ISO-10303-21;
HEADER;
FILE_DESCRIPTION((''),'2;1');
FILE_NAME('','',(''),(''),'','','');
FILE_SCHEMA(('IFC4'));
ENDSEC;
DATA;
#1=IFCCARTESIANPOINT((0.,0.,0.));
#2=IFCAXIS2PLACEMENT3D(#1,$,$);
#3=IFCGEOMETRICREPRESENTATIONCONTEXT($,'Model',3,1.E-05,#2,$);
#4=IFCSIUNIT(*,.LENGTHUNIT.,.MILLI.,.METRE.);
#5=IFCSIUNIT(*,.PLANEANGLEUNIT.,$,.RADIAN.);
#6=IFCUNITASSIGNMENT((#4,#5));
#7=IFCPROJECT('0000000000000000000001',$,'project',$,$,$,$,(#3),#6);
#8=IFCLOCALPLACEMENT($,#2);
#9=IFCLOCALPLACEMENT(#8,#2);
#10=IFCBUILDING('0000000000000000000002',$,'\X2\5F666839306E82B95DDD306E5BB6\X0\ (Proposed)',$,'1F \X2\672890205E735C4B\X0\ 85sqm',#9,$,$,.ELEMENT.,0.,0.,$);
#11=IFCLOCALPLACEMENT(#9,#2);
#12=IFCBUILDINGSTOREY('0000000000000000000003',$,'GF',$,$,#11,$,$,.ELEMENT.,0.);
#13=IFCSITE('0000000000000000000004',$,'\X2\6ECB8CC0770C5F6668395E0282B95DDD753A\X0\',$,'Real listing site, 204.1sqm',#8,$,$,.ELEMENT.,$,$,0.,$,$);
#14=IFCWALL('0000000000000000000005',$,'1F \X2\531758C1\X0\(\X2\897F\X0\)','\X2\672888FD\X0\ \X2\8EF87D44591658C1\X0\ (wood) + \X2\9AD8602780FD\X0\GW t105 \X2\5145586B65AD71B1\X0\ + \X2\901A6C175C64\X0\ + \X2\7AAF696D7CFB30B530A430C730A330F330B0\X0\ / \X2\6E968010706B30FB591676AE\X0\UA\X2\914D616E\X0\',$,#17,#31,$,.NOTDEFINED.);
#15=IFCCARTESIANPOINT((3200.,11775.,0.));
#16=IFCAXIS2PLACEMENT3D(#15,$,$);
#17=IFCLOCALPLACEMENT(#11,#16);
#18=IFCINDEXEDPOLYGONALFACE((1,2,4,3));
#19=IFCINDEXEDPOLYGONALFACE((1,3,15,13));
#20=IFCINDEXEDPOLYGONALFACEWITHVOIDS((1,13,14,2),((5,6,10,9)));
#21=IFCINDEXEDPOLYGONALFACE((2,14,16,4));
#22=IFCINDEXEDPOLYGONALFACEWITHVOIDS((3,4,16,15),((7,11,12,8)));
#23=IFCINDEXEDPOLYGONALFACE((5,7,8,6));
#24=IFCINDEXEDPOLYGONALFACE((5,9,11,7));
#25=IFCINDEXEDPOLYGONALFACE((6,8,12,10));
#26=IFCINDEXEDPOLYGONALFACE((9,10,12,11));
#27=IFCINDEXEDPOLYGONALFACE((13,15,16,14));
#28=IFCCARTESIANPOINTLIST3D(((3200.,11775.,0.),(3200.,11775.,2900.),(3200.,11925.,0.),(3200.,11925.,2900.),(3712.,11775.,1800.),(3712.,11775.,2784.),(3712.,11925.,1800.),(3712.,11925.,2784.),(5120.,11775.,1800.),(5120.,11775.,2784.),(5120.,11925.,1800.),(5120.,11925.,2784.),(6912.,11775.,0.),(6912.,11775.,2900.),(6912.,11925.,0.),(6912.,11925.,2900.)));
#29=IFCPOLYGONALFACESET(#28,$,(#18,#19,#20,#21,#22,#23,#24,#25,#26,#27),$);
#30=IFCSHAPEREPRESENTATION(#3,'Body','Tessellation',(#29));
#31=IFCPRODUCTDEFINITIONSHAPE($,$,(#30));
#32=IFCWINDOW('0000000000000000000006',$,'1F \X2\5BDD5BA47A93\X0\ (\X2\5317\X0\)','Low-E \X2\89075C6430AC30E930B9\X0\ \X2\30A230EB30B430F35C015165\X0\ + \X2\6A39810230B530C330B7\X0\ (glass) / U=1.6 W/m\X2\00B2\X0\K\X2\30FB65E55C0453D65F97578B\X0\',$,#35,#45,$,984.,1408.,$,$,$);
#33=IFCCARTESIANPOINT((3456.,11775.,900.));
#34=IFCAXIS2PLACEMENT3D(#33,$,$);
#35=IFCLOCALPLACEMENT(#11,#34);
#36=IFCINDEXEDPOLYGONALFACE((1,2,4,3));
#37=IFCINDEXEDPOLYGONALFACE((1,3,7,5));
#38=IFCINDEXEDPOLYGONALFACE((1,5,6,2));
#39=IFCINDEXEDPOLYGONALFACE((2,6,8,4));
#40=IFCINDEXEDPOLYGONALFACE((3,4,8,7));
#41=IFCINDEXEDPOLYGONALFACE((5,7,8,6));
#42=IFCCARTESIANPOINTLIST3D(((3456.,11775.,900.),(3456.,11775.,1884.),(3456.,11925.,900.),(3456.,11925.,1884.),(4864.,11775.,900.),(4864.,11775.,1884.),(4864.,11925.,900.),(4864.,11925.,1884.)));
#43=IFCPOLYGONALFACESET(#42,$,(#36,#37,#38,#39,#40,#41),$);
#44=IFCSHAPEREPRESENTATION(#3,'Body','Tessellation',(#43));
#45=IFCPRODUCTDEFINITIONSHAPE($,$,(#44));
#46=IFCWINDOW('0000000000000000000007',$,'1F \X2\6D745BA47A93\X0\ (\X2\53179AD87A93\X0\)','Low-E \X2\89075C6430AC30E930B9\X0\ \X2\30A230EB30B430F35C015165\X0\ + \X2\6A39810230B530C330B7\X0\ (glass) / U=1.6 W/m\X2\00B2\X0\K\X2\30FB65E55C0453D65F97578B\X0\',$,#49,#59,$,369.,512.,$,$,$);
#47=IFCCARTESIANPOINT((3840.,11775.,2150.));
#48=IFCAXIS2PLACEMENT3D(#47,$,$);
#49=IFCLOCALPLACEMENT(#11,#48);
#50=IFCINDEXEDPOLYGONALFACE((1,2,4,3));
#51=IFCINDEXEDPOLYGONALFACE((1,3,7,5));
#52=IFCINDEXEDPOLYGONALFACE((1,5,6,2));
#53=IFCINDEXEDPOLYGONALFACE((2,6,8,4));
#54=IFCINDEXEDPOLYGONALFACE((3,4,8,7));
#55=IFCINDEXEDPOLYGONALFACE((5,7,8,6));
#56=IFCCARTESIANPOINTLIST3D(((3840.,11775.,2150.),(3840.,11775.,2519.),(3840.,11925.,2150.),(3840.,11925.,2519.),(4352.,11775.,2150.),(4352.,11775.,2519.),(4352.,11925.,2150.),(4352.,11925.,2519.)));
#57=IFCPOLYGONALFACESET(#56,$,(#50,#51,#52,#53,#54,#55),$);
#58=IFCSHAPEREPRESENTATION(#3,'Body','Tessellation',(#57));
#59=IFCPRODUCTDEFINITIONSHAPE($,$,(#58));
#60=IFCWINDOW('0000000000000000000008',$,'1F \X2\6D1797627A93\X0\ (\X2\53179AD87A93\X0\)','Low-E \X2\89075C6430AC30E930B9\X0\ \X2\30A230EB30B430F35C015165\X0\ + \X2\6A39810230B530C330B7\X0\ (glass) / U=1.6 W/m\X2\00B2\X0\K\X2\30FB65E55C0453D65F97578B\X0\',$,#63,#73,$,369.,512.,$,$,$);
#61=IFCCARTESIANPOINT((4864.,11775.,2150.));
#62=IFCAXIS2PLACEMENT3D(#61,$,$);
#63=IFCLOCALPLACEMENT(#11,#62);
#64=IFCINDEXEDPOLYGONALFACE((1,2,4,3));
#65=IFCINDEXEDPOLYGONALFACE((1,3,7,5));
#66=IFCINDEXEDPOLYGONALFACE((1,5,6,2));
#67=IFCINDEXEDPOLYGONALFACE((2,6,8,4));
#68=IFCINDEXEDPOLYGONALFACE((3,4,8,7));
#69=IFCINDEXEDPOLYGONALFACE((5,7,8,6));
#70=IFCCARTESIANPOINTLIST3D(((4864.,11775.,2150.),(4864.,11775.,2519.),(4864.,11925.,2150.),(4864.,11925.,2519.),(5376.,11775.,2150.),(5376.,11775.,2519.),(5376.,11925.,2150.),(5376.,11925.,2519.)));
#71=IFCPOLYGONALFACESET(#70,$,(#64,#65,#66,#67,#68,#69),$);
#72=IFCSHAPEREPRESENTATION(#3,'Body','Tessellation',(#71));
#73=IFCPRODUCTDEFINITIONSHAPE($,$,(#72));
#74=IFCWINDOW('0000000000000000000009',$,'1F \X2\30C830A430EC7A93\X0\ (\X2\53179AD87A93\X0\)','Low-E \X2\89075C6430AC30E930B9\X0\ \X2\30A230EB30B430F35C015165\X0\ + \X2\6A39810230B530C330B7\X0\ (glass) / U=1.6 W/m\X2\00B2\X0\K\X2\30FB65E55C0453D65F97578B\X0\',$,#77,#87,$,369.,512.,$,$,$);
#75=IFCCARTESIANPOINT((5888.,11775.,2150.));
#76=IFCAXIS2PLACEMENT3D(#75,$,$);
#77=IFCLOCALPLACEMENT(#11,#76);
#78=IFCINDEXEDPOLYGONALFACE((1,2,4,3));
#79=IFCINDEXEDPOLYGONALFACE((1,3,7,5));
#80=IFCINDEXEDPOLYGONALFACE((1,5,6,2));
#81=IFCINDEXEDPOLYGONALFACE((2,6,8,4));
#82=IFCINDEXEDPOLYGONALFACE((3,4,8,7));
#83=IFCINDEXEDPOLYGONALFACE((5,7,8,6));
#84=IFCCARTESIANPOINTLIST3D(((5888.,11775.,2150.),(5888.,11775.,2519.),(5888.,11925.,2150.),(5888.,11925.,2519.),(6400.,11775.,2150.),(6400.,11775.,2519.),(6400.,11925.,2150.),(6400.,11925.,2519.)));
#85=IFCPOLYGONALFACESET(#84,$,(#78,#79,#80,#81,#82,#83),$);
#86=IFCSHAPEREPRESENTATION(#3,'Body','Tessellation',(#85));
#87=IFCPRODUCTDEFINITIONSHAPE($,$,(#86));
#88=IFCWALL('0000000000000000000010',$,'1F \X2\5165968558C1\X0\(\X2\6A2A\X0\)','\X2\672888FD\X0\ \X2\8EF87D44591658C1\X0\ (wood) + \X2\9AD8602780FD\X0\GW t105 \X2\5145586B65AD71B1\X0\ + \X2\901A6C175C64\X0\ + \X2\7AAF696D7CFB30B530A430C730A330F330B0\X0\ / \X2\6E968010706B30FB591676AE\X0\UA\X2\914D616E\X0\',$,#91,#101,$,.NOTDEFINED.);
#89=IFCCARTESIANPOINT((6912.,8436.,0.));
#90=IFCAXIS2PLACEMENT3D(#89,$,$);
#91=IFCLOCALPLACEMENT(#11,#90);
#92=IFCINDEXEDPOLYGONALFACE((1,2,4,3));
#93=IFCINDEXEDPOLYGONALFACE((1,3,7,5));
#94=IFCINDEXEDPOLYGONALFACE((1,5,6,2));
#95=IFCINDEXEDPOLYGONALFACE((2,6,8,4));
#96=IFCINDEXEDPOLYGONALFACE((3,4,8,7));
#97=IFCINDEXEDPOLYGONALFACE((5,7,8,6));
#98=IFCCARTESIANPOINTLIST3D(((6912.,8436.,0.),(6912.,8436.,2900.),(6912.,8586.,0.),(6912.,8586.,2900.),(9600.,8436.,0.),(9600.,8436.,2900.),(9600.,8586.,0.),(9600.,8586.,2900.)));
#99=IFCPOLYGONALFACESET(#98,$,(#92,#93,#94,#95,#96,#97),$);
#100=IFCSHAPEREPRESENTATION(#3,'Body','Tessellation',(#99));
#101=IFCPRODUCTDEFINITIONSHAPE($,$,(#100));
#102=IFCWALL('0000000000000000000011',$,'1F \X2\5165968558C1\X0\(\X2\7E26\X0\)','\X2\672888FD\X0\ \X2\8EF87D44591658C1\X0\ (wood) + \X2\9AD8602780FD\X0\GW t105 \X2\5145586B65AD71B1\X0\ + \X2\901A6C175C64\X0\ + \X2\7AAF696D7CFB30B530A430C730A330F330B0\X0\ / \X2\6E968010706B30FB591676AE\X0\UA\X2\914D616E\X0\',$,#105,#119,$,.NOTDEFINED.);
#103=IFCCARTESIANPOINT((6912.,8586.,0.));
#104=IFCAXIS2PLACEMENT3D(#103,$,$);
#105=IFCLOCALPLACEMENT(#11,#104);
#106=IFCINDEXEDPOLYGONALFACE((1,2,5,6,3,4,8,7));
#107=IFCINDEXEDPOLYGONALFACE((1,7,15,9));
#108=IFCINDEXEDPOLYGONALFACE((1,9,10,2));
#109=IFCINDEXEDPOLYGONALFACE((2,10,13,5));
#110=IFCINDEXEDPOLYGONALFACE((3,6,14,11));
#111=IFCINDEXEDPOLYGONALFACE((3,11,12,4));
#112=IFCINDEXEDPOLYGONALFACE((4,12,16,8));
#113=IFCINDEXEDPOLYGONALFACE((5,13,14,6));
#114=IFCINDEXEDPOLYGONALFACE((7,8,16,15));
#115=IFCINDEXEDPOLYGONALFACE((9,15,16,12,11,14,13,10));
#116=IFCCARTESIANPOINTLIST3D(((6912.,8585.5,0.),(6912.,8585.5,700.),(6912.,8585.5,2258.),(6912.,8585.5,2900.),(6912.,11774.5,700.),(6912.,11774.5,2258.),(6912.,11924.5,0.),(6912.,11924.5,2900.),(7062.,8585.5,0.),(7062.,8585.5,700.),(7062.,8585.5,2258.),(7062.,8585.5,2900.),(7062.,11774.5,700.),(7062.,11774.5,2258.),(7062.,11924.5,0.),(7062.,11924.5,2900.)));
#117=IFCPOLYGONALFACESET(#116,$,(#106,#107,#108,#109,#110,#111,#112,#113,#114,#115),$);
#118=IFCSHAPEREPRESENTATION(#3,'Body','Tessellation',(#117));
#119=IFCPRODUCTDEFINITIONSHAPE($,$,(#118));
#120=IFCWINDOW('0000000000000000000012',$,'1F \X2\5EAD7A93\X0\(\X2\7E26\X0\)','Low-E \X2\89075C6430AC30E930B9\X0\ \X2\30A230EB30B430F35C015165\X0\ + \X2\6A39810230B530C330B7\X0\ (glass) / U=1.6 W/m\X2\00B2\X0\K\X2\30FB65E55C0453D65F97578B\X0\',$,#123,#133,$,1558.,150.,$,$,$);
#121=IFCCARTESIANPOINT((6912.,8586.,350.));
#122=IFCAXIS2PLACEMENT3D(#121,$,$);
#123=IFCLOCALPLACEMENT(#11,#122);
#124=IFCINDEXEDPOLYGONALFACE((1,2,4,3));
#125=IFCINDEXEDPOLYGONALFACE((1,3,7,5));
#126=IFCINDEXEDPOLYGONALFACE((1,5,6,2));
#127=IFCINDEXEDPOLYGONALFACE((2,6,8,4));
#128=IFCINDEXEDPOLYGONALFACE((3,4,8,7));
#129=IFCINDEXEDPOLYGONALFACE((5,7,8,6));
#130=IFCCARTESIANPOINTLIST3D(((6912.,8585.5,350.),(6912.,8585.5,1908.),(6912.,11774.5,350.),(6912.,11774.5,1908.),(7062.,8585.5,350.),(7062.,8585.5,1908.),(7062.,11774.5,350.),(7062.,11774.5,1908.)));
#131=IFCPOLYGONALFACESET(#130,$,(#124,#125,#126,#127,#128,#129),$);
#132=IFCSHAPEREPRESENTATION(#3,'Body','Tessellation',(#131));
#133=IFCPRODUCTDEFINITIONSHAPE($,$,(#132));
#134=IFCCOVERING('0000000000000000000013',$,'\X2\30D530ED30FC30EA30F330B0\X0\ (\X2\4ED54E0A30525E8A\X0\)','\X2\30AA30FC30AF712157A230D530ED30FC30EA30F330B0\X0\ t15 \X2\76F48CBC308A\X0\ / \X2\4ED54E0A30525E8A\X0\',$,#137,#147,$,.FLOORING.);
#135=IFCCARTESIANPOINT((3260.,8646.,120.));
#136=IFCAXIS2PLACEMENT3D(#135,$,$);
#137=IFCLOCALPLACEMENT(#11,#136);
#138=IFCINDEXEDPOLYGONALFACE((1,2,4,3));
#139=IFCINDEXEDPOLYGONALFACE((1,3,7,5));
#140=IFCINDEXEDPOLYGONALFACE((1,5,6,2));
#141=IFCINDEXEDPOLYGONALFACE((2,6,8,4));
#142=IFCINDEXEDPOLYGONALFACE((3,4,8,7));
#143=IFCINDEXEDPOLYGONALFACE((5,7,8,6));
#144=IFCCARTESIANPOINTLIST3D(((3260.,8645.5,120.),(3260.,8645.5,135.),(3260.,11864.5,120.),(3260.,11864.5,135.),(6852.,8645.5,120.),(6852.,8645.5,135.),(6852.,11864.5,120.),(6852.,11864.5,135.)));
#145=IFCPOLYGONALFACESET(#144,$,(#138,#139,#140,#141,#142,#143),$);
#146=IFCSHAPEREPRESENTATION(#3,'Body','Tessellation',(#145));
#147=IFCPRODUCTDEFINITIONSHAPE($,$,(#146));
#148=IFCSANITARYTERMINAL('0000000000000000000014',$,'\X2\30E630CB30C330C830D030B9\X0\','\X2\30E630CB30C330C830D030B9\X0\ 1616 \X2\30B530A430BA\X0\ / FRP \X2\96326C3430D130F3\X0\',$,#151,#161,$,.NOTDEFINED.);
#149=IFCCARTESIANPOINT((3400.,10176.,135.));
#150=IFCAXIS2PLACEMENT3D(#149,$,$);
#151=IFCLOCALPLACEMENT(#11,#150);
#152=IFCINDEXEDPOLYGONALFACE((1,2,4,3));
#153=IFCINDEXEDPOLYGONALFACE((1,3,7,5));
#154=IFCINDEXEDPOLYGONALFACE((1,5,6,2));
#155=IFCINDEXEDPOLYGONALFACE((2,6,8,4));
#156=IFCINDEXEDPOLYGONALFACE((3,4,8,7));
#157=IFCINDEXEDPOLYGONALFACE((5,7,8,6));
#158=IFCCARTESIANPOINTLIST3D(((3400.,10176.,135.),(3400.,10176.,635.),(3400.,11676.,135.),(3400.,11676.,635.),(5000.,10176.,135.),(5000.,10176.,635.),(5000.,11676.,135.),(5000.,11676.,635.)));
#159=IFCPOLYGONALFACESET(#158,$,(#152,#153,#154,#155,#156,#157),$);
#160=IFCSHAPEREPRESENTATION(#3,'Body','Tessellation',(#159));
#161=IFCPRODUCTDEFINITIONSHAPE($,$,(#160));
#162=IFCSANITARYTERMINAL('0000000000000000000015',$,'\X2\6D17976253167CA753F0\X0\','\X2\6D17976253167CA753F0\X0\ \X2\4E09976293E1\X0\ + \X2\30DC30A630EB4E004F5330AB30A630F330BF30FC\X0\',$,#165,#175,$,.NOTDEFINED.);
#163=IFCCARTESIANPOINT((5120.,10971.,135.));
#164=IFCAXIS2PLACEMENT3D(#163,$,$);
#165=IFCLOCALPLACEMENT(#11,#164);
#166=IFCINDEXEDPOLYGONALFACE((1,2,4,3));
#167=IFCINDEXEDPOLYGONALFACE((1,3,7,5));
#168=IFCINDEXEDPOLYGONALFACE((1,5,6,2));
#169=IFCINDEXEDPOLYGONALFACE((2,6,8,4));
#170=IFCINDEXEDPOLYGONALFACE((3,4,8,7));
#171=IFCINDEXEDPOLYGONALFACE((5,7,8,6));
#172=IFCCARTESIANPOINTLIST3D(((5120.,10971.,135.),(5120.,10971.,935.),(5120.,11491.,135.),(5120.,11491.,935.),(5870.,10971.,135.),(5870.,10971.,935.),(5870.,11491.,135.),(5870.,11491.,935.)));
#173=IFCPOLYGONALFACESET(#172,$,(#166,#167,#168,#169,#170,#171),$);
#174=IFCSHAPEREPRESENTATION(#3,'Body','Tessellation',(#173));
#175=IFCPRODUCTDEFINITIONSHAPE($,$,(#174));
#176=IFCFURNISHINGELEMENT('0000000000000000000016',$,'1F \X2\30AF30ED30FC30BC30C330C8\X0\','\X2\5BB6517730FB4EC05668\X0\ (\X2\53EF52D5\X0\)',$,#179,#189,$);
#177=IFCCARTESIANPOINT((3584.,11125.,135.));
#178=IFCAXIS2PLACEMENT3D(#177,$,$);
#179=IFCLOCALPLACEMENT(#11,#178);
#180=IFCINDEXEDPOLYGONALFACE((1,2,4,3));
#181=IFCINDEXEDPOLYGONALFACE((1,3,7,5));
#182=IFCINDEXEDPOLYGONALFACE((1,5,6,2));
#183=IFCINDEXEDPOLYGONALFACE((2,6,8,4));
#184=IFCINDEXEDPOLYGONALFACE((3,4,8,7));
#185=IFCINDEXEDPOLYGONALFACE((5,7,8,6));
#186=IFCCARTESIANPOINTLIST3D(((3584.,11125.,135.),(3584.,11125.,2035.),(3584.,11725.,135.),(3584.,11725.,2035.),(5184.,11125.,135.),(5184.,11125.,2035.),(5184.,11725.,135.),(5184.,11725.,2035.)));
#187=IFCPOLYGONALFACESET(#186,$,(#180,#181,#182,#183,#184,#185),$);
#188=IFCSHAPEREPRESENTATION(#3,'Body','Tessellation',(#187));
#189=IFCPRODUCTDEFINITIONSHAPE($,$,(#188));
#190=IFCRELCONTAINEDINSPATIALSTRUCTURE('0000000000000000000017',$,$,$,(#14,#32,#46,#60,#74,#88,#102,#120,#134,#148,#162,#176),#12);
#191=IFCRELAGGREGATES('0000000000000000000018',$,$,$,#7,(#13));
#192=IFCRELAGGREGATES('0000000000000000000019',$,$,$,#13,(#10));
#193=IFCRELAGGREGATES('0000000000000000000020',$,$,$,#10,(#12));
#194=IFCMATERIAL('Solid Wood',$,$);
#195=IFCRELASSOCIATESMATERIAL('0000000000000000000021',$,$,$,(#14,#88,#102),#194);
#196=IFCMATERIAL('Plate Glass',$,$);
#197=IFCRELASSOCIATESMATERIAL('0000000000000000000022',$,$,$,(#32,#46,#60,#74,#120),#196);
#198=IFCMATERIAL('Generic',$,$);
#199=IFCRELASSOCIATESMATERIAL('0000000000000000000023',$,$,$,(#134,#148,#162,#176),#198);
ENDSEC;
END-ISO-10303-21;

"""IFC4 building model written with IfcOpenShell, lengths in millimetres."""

from ifc_helpers import new_model, si_unit, frame, frame_2d, origin, place, context, project, spatial, rectangle, extrude, material, element, fill, save


model = new_model("IFC4")

# Units and contexts
model_context = context("Model", 3, precision=1e-05, world=origin())
ifc_project = project(units=[si_unit("LENGTHUNIT", "METRE", prefix="MILLI"), si_unit("PLANEANGLEUNIT", "RADIAN")], contexts=[model_context])

# Site, building, storey
site_placement = place(None, origin())
site = spatial("IfcSite", under=ifc_project, at=site_placement, Name="滋賀県彦根市芹川町", ObjectType="Real listing site, 204.1sqm", CompositionType="ELEMENT", RefElevation=0.0)
building_placement = place(site_placement, origin())
building = spatial("IfcBuilding", under=site, at=building_placement, Name="彦根の芹川の家 (Proposed)", ObjectType="1F 木造平屋 85sqm", CompositionType="ELEMENT", ElevationOfRefHeight=0.0, ElevationOfTerrain=0.0)
storey_placement = place(building_placement, origin())
storey = spatial("IfcBuildingStorey", under=building, at=storey_placement, Name="GF", CompositionType="ELEMENT", Elevation=0.0)

# Shared definitions
ifc_material_1 = material(Name="Solid Wood")

# Wall, openings, windows
wall_1_placement = place(storey_placement, frame((3200.0, 11775.0, 0.0)))
wall_1 = element("IfcWall", 1, at=wall_1_placement, inside=storey, material=ifc_material_1, Name="1F 北壁(西)", Description="木製 軸組外壁 (wood) + 高性能GW t105 充填断熱 + 通気層 + 窯業系サイディング / 準耐火・外皮UA配慮", PredefinedType="NOTDEFINED", context=model_context, shape_type="SweptSolid", body=[
    extrude(rectangle(XDim=3712.0, YDim=150.0, at=frame_2d((1856.0, 75.0))), frame((3200.0, 11775.0, 0.0)), (0.0, 0.0, 1.0), 2900.0),
])
opening_1_placement = place(storey_placement, frame((3456.0, 11775.0, 900.0)))
opening_1 = element("IfcOpeningElement", 2, at=opening_1_placement, cuts=wall_1, PredefinedType="NOTDEFINED", context=model_context, shape_type="SweptSolid", body=[
    extrude(rectangle(XDim=1408.0, YDim=150.0, at=frame_2d((704.0, 75.0))), frame((3456.0, 11775.0, 900.0)), (0.0, 0.0, 1.0), 984.0),
])
opening_2_placement = place(storey_placement, frame((3840.0, 11775.0, 2150.0)))
opening_2 = element("IfcOpeningElement", 3, at=opening_2_placement, cuts=wall_1, PredefinedType="NOTDEFINED", context=model_context, shape_type="SweptSolid", body=[
    extrude(rectangle(XDim=512.0, YDim=150.0, at=frame_2d((256.0, 75.0))), frame((3840.0, 11775.0, 2150.0)), (0.0, 0.0, 1.0), 369.0),
])
opening_3_placement = place(storey_placement, frame((4864.0, 11775.0, 2150.0)))
opening_3 = element("IfcOpeningElement", 4, at=opening_3_placement, cuts=wall_1, PredefinedType="NOTDEFINED", context=model_context, shape_type="SweptSolid", body=[
    extrude(rectangle(XDim=512.0, YDim=150.0, at=frame_2d((256.0, 75.0))), frame((4864.0, 11775.0, 2150.0)), (0.0, 0.0, 1.0), 369.0),
])
opening_4_placement = place(storey_placement, frame((5888.0, 11775.0, 2150.0)))
opening_4 = element("IfcOpeningElement", 5, at=opening_4_placement, cuts=wall_1, PredefinedType="NOTDEFINED", context=model_context, shape_type="SweptSolid", body=[
    extrude(rectangle(XDim=512.0, YDim=150.0, at=frame_2d((256.0, 75.0))), frame((5888.0, 11775.0, 2150.0)), (0.0, 0.0, 1.0), 369.0),
])
ifc_material_2 = material(Name="Plate Glass")
window_1_placement = place(storey_placement, frame((3456.0, 11775.0, 900.0)))
window_1 = element("IfcWindow", 6, at=window_1_placement, inside=storey, material=ifc_material_2, Name="1F 寝室窓 (北)", Description="Low-E 複層ガラス アルゴン封入 + 樹脂サッシ (glass) / U=1.6 W/m²K・日射取得型", OverallHeight=984.0, OverallWidth=1408.0, context=model_context, shape_type="SweptSolid", body=[
    extrude(rectangle(XDim=1408.0, YDim=150.0, at=frame_2d((704.0, 75.0))), frame((3456.0, 11775.0, 900.0)), (0.0, 0.0, 1.0), 984.0),
])
fill(opening_1, window_1)
window_2_placement = place(storey_placement, frame((3840.0, 11775.0, 2150.0)))
window_2 = element("IfcWindow", 7, at=window_2_placement, inside=storey, material=ifc_material_2, Name="1F 浴室窓 (北高窓)", Description="Low-E 複層ガラス アルゴン封入 + 樹脂サッシ (glass) / U=1.6 W/m²K・日射取得型", OverallHeight=369.0, OverallWidth=512.0, context=model_context, shape_type="SweptSolid", body=[
    extrude(rectangle(XDim=512.0, YDim=150.0, at=frame_2d((256.0, 75.0))), frame((3840.0, 11775.0, 2150.0)), (0.0, 0.0, 1.0), 369.0),
])
fill(opening_2, window_2)
window_3_placement = place(storey_placement, frame((4864.0, 11775.0, 2150.0)))
window_3 = element("IfcWindow", 8, at=window_3_placement, inside=storey, material=ifc_material_2, Name="1F 洗面窓 (北高窓)", Description="Low-E 複層ガラス アルゴン封入 + 樹脂サッシ (glass) / U=1.6 W/m²K・日射取得型", OverallHeight=369.0, OverallWidth=512.0, context=model_context, shape_type="SweptSolid", body=[
    extrude(rectangle(XDim=512.0, YDim=150.0, at=frame_2d((256.0, 75.0))), frame((4864.0, 11775.0, 2150.0)), (0.0, 0.0, 1.0), 369.0),
])
fill(opening_3, window_3)
window_4_placement = place(storey_placement, frame((5888.0, 11775.0, 2150.0)))
window_4 = element("IfcWindow", 9, at=window_4_placement, inside=storey, material=ifc_material_2, Name="1F トイレ窓 (北高窓)", Description="Low-E 複層ガラス アルゴン封入 + 樹脂サッシ (glass) / U=1.6 W/m²K・日射取得型", OverallHeight=369.0, OverallWidth=512.0, context=model_context, shape_type="SweptSolid", body=[
    extrude(rectangle(XDim=512.0, YDim=150.0, at=frame_2d((256.0, 75.0))), frame((5888.0, 11775.0, 2150.0)), (0.0, 0.0, 1.0), 369.0),
])
fill(opening_4, window_4)

# Wall
wall_2_placement = place(storey_placement, frame((6912.0, 8436.0, 0.0)))
element("IfcWall", 10, at=wall_2_placement, inside=storey, material=ifc_material_1, Name="1F 入隅壁(横)", Description="木製 軸組外壁 (wood) + 高性能GW t105 充填断熱 + 通気層 + 窯業系サイディング / 準耐火・外皮UA配慮", PredefinedType="NOTDEFINED", context=model_context, shape_type="SweptSolid", body=[
    extrude(rectangle(XDim=2688.0, YDim=150.0, at=frame_2d((1344.0, 75.0))), frame((6912.0, 8436.0, 0.0)), (0.0, 0.0, 1.0), 2900.0),
])

# Wall, opening, window
wall_3_placement = place(storey_placement, frame((6912.0, 8586.0, 0.0)))
wall_3 = element("IfcWall", 11, at=wall_3_placement, inside=storey, material=ifc_material_1, Name="1F 入隅壁(縦)", Description="木製 軸組外壁 (wood) + 高性能GW t105 充填断熱 + 通気層 + 窯業系サイディング / 準耐火・外皮UA配慮", PredefinedType="NOTDEFINED", context=model_context, shape_type="SweptSolid", body=[
    extrude(rectangle(XDim=150.0, YDim=3339.0, at=frame_2d((75.0, 1669.0))), frame((6912.0, 8586.0, 0.0)), (0.0, 0.0, 1.0), 2900.0),
])
opening_5_placement = place(storey_placement, frame((6912.0, 8586.0, 350.0)))
opening_5 = element("IfcOpeningElement", 12, at=opening_5_placement, cuts=wall_3, PredefinedType="NOTDEFINED", context=model_context, shape_type="SweptSolid", body=[
    extrude(rectangle(XDim=150.0, YDim=3189.0, at=frame_2d((75.0, 1594.0))), frame((6912.0, 8586.0, 350.0)), (0.0, 0.0, 1.0), 1558.0),
])
window_5_placement = place(storey_placement, frame((6912.0, 8586.0, 350.0)))
window_5 = element("IfcWindow", 13, at=window_5_placement, inside=storey, material=ifc_material_2, Name="1F 庭窓(縦)", Description="Low-E 複層ガラス アルゴン封入 + 樹脂サッシ (glass) / U=1.6 W/m²K・日射取得型", OverallHeight=1558.0, OverallWidth=150.0, context=model_context, shape_type="SweptSolid", body=[
    extrude(rectangle(XDim=150.0, YDim=3189.0, at=frame_2d((75.0, 1594.0))), frame((6912.0, 8586.0, 350.0)), (0.0, 0.0, 1.0), 1558.0),
])
fill(opening_5, window_5)

# Covering
ifc_material_3 = material(Name="Generic")
covering_placement = place(storey_placement, frame((3260.0, 8646.0, 120.0)))
element("IfcCovering", 14, at=covering_placement, inside=storey, material=ifc_material_3, Name="フローリング (仕上げ床)", Description="オーク無垢フローリング t15 直貼り / 仕上げ床", PredefinedType="FLOORING", context=model_context, shape_type="SweptSolid", body=[
    extrude(rectangle(XDim=3592.0, YDim=3219.0, at=frame_2d((1796.0, 1609.0))), frame((3260.0, 8646.0, 120.0)), (0.0, 0.0, 1.0), 15.0),
])

# Sanitary terminals
sanitary_terminal_1_placement = place(storey_placement, frame((3400.0, 10176.0, 135.0)))
element("IfcSanitaryTerminal", 15, at=sanitary_terminal_1_placement, inside=storey, material=ifc_material_3, Name="ユニットバス", Description="ユニットバス 1616 サイズ / FRP 防水パン", PredefinedType="NOTDEFINED", context=model_context, shape_type="SweptSolid", body=[
    extrude(rectangle(XDim=1600.0, YDim=1500.0, at=frame_2d((800.0, 750.0))), frame((3400.0, 10176.0, 135.0)), (0.0, 0.0, 1.0), 500.0),
])
sanitary_terminal_2_placement = place(storey_placement, frame((5120.0, 10971.0, 135.0)))
element("IfcSanitaryTerminal", 16, at=sanitary_terminal_2_placement, inside=storey, material=ifc_material_3, Name="洗面化粧台", Description="洗面化粧台 三面鏡 + ボウル一体カウンター", PredefinedType="NOTDEFINED", context=model_context, shape_type="SweptSolid", body=[
    extrude(rectangle(XDim=750.0, YDim=520.0, at=frame_2d((375.0, 260.0))), frame((5120.0, 10971.0, 135.0)), (0.0, 0.0, 1.0), 800.0),
])

# Furnishing element
furnishing_1_placement = place(storey_placement, frame((3584.0, 11125.0, 135.0)))
element("IfcFurnishingElement", 17, at=furnishing_1_placement, inside=storey, material=ifc_material_3, Name="1F クローゼット", Description="家具・什器 (可動)", context=model_context, shape_type="SweptSolid", body=[
    extrude(rectangle(XDim=1600.0, YDim=600.0, at=frame_2d((800.0, 300.0))), frame((3584.0, 11125.0, 135.0)), (0.0, 0.0, 1.0), 1900.0),
])

save(model, "model.ifc")
